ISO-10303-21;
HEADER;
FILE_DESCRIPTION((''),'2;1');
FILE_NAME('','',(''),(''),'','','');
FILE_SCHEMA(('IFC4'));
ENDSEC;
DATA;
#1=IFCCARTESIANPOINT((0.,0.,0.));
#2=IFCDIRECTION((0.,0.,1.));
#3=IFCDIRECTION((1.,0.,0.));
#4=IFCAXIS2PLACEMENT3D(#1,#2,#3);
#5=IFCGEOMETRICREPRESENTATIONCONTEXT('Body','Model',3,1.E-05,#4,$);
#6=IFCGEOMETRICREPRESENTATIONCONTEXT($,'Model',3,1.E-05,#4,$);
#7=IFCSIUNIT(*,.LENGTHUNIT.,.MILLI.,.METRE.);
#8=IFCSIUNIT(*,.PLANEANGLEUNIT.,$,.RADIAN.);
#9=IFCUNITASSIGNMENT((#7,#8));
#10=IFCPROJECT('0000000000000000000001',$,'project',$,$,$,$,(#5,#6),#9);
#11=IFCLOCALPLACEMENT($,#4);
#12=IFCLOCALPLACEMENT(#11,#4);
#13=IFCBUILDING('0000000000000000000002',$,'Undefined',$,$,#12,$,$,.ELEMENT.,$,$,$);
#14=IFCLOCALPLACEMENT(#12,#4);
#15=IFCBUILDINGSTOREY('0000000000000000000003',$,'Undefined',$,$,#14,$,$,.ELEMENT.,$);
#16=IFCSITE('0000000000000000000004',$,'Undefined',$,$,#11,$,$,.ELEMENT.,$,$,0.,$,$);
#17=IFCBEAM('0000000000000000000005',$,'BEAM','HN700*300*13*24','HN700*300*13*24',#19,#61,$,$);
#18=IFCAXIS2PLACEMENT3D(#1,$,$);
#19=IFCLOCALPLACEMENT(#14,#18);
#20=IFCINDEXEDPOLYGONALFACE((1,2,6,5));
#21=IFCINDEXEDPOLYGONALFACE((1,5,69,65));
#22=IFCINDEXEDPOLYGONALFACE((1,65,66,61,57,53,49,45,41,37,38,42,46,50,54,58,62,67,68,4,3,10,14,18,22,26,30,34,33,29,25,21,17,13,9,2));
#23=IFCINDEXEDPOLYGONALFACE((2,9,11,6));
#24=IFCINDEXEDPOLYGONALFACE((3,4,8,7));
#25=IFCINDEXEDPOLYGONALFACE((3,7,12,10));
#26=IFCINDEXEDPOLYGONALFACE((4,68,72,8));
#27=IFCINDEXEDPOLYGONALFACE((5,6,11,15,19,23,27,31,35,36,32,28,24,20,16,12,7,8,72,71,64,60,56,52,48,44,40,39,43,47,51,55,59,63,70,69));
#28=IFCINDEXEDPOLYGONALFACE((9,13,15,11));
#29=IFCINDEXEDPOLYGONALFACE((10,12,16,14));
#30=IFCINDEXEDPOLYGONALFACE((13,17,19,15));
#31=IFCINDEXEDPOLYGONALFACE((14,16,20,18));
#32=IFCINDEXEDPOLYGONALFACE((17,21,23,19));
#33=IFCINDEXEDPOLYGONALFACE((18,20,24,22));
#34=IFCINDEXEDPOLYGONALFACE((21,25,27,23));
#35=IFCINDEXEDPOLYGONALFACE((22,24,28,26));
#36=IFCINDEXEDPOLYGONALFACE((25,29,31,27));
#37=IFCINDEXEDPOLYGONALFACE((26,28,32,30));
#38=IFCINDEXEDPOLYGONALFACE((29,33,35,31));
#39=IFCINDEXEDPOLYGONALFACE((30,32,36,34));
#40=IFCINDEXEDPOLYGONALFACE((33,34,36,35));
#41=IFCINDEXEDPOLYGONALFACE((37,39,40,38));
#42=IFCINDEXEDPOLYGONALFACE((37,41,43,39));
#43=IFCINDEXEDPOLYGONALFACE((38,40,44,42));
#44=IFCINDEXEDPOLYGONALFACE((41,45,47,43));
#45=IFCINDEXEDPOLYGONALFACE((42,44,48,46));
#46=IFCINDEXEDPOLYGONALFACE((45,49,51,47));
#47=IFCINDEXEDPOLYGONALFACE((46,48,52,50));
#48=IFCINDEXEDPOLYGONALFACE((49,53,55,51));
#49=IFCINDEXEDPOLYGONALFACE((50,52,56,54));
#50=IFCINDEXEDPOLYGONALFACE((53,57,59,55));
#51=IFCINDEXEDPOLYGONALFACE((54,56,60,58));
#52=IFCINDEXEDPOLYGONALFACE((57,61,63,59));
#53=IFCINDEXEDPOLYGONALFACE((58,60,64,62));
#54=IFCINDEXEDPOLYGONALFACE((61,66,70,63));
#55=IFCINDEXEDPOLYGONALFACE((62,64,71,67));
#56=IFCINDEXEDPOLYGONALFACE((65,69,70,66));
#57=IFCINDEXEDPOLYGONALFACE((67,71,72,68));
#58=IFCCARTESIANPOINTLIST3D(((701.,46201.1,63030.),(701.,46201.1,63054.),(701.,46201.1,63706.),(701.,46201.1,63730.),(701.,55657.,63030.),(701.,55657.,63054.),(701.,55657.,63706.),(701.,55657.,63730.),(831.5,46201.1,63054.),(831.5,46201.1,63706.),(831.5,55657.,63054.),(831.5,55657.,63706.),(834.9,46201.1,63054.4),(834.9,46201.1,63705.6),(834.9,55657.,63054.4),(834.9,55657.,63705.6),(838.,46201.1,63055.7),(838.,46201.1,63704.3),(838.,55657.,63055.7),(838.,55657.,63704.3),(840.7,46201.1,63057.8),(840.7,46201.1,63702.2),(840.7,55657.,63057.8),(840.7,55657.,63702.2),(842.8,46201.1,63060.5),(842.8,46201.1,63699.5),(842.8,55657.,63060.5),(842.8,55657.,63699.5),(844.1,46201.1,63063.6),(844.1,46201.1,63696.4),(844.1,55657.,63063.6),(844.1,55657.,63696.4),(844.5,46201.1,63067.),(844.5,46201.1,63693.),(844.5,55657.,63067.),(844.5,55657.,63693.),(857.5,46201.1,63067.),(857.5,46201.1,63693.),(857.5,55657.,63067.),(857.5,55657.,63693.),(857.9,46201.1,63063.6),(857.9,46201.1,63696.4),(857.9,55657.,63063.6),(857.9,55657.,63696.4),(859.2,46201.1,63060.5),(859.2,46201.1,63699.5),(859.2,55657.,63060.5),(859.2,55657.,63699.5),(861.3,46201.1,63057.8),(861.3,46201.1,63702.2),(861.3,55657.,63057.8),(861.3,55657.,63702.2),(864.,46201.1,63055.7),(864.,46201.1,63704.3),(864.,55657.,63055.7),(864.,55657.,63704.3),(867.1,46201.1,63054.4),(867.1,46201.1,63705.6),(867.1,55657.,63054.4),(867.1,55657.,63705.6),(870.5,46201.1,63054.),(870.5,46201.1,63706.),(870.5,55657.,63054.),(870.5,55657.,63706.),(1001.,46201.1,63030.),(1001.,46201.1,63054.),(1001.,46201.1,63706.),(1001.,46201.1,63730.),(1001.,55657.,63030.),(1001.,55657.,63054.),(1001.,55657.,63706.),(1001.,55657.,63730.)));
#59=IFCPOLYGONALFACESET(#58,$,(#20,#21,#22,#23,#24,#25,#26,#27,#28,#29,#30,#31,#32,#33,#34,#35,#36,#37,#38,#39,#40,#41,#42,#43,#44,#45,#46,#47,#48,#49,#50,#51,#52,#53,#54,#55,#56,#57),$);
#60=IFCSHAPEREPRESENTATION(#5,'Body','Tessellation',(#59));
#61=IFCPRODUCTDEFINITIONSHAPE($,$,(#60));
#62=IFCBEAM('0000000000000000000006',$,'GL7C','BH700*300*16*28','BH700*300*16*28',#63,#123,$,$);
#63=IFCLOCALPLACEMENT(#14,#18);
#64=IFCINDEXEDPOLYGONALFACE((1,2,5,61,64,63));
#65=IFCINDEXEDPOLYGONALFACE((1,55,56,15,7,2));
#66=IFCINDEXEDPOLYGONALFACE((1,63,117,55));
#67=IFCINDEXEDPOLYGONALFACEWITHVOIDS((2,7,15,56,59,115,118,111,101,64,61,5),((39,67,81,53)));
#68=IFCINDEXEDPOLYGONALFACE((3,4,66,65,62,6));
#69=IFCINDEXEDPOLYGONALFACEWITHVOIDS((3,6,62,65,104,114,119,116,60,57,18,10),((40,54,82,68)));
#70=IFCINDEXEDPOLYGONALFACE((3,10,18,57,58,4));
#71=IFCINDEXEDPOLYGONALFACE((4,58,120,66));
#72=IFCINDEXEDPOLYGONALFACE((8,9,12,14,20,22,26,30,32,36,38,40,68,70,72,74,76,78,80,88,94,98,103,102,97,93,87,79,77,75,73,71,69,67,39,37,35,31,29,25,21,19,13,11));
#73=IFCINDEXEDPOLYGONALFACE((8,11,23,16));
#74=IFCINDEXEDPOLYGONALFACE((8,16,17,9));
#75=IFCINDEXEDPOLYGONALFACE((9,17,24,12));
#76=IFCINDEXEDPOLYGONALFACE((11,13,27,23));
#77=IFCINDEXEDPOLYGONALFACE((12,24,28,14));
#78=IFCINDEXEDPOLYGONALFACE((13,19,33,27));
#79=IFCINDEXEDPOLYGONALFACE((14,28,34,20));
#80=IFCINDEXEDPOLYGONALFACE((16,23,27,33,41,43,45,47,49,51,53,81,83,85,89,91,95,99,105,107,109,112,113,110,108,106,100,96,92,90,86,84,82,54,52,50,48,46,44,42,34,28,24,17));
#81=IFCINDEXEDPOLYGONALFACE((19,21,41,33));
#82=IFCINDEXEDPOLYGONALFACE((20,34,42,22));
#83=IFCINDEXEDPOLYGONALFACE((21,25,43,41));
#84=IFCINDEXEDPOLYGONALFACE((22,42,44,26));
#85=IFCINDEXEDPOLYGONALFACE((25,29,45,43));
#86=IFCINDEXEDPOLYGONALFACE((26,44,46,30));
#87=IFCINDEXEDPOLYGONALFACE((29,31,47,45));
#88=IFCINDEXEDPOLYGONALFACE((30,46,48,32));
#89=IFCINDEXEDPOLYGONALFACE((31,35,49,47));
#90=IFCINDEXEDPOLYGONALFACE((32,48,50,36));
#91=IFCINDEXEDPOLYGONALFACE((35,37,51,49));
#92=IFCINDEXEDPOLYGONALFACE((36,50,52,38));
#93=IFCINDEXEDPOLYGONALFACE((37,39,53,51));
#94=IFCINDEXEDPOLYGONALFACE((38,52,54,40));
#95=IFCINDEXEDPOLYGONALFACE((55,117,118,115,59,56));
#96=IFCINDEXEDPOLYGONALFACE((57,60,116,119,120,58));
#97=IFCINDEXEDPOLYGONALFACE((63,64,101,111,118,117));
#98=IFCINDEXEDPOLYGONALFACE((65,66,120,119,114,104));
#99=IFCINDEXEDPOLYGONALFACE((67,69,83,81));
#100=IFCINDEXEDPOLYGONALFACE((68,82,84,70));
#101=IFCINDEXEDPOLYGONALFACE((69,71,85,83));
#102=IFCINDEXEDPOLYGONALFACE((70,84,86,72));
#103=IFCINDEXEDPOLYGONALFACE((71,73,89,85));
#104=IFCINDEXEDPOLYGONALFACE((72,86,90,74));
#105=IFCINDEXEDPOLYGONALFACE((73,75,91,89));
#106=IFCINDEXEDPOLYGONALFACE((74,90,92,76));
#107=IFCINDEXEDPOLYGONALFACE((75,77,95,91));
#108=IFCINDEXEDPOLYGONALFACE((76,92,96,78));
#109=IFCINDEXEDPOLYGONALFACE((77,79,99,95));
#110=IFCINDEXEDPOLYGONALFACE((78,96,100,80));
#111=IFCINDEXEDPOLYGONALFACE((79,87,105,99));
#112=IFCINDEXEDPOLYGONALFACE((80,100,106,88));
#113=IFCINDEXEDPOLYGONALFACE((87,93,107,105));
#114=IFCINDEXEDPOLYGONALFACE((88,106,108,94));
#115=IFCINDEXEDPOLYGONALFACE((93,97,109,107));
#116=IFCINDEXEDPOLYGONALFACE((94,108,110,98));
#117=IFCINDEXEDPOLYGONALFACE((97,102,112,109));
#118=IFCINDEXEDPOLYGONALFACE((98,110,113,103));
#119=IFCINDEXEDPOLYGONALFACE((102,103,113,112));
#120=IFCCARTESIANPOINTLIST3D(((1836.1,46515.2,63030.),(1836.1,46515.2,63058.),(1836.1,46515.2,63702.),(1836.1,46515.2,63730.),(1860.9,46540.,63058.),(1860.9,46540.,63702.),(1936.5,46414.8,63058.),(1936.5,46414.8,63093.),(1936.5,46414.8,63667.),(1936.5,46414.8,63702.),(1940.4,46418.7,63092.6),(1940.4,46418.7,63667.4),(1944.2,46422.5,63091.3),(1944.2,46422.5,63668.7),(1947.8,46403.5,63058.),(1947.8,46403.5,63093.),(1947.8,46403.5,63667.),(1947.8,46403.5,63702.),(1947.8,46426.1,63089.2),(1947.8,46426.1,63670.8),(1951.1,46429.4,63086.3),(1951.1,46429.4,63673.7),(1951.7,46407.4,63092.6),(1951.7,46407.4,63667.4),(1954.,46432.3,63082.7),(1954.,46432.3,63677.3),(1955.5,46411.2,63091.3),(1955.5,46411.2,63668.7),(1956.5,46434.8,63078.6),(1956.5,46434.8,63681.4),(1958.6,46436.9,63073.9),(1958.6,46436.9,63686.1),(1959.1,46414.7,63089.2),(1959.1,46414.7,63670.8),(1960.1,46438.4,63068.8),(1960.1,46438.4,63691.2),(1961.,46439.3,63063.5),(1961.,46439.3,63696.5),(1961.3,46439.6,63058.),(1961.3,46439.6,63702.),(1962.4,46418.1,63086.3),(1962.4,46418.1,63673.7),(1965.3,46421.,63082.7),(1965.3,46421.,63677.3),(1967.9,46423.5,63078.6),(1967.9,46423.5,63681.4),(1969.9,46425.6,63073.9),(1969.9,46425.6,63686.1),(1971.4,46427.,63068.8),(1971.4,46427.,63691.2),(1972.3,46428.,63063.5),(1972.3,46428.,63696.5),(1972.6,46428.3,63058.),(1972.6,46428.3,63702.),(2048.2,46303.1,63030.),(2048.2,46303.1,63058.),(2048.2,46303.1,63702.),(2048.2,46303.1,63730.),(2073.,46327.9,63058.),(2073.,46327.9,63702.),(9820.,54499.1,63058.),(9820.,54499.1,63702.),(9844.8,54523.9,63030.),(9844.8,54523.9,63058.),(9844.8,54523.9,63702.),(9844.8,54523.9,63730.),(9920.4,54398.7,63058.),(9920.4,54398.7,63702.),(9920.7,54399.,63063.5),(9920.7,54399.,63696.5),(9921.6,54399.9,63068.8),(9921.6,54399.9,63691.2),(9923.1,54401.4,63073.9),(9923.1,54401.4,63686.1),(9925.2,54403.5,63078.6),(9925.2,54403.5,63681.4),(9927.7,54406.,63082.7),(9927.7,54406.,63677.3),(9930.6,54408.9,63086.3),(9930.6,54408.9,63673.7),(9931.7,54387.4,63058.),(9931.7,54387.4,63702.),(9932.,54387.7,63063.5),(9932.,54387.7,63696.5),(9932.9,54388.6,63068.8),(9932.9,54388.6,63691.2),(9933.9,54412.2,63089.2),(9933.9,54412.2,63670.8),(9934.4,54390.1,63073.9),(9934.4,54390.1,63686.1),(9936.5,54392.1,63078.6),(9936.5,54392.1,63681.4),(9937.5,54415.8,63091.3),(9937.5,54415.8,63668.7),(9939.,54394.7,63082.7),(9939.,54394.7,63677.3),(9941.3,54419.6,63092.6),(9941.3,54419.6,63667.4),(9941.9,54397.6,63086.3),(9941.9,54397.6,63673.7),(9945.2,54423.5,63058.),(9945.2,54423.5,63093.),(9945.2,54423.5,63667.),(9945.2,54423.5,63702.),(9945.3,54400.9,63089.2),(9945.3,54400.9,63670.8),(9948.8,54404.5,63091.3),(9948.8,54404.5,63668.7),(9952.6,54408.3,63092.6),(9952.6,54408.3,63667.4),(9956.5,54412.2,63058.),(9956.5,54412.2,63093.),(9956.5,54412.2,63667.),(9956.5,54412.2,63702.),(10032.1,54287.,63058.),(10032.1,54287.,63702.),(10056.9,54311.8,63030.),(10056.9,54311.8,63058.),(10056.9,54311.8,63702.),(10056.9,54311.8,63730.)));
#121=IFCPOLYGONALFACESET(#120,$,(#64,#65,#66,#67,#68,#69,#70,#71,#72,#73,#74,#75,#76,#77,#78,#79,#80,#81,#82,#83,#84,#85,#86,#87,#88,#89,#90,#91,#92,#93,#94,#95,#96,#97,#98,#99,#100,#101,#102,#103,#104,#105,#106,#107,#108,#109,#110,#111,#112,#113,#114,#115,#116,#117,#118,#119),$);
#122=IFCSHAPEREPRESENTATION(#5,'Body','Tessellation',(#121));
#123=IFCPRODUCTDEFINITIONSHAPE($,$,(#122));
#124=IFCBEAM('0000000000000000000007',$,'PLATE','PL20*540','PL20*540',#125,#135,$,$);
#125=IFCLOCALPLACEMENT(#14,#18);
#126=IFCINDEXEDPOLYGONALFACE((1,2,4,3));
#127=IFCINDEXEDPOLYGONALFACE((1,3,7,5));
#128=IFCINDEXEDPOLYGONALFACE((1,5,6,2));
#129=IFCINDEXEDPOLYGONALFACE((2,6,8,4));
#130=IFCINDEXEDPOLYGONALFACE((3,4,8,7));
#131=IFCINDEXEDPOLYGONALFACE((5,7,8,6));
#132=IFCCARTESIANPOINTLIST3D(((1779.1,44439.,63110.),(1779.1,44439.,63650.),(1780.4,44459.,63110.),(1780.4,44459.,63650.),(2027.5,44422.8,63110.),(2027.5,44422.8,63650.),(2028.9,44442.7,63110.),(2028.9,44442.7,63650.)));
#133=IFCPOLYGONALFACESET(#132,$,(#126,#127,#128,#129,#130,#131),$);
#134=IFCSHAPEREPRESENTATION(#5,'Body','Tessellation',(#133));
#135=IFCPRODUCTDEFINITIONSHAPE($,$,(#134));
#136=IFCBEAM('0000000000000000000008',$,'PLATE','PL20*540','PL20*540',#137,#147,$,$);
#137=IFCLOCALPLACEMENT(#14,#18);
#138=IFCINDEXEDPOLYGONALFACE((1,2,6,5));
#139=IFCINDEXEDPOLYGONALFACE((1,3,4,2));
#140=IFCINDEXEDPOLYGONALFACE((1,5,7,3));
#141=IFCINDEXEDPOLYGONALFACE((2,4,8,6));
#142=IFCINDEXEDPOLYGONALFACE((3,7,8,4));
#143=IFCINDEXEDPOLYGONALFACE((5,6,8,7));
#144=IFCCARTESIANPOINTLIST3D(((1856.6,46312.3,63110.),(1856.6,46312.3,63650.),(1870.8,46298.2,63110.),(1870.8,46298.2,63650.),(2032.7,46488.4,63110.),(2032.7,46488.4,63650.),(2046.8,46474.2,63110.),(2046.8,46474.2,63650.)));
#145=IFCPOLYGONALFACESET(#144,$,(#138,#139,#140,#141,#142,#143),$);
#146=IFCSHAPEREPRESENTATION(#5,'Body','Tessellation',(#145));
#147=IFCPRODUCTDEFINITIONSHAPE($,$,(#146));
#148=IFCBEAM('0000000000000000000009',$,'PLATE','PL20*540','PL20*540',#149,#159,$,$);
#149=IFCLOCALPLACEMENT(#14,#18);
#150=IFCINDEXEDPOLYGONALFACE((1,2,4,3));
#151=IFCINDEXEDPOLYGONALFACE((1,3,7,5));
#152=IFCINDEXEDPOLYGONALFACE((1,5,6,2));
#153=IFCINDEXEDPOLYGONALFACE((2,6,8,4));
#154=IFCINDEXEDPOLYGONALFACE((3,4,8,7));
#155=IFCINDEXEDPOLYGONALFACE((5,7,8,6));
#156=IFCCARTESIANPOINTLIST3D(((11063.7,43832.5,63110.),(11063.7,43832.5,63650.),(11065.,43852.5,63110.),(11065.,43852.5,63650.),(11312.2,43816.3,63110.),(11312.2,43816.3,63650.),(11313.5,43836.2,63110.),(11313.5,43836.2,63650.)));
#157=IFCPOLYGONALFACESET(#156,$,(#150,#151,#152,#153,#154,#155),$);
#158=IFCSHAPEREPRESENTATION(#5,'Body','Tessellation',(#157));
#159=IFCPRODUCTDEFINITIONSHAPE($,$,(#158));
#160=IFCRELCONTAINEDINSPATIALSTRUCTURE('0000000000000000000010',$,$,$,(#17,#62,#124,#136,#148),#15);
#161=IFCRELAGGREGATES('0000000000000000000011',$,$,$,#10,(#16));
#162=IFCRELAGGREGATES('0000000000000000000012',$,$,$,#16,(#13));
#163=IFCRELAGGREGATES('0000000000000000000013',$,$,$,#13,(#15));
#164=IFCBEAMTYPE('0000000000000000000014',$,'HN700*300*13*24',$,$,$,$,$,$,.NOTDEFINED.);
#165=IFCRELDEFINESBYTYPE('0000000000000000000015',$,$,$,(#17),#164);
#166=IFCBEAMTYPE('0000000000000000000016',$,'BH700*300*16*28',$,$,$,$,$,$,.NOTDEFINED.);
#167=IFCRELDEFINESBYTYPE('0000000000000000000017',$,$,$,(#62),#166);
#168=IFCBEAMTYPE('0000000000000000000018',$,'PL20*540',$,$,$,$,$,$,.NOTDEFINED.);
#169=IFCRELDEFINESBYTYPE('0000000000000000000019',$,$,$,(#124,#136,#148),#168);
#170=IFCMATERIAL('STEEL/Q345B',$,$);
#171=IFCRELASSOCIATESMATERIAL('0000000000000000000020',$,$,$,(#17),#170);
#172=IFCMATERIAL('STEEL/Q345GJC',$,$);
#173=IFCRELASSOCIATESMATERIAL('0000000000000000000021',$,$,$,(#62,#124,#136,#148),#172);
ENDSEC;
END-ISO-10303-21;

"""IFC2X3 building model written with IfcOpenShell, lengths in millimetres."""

from ifc_helpers import new_model, si_unit, frame, origin_with_axes, origin_2d_with_axis, place, context, project, spatial, polyline, rectangle, i_section, outline, extrude, material, type_object, element, save


model = new_model("IFC2X3")

# Units and contexts
model_context_1 = context("Model", 3, precision=1e-05, world=origin_with_axes(), identifier="Body")
model_context_2 = context("Model", 3, precision=1e-05, world=origin_with_axes())
ifc_project = project(units=[si_unit("LENGTHUNIT", "METRE", prefix="MILLI"), si_unit("PLANEANGLEUNIT", "RADIAN")], contexts=[model_context_1, model_context_2])

# Site, building, storey
site_placement = place(None, origin_with_axes())
site = spatial("IfcSite", under=ifc_project, at=site_placement, Name="Undefined", CompositionType="ELEMENT", RefElevation=0.0)
building_placement = place(site_placement, origin_with_axes())
building = spatial("IfcBuilding", under=site, at=building_placement, Name="Undefined", CompositionType="ELEMENT")
storey_placement = place(building_placement, origin_with_axes())
storey = spatial("IfcBuildingStorey", under=building, at=storey_placement, Name="Undefined", CompositionType="ELEMENT")

# Beam
ifc_material_1 = material(Name="STEEL/Q345B")
beam_type_1 = type_object("IfcBeamType", Name="HN700*300*13*24", PredefinedType="NOTDEFINED")
beam_1_placement = place(storey_placement, frame((851.0, 46201.1, 63380.0), z_axis=(0.0, 0.0, 1.0), x_axis=(0.0, 1.0, 0.0)))
element("IfcBeam", 1, at=beam_1_placement, inside=storey, type_object=beam_type_1, material=ifc_material_1, Name="BEAM", Description="HN700*300*13*24", ObjectType="HN700*300*13*24", context=model_context_1, shape_type="SweptSolid", body=[
    extrude(i_section(OverallWidth=300.0, OverallDepth=700.0, WebThickness=13.0, FlangeThickness=24.0, FilletRadius=13.0, at=origin_2d_with_axis()), frame((9455.9, 0.0, 0.0), z_axis=(-1.0, 0.0, 0.0), x_axis=(0.0, -1.0, 0.0)), (0.0, 0.0, 1.0), 9455.9),
])
ifc_material_2 = material(Name="STEEL/Q345GJC")
beam_type_2 = type_object("IfcBeamType", Name="BH700*300*16*28", PredefinedType="NOTDEFINED")

# Beam, openings
beam_2_placement = place(storey_placement, frame((992.3, 45459.3, 63380.0), z_axis=(0.0, 0.0, 1.0), x_axis=(0.707107, 0.707107, 0.0)))
beam_2 = element("IfcBeam", 2, at=beam_2_placement, inside=storey, type_object=beam_type_2, material=ifc_material_2, Name="GL7C", Description="BH700*300*16*28", ObjectType="BH700*300*16*28", context=model_context_1, shape_type="SweptSolid", body=[
    extrude(i_section(OverallWidth=300.0, OverallDepth=700.0, WebThickness=16.0, FlangeThickness=28.0, at=origin_2d_with_axis()), frame((12669.3, 0.0, 0.0), z_axis=(-1.0, 0.0, 0.0), x_axis=(0.0, -1.0, 0.0)), (0.0, 0.0, 1.0), 11325.9),
])
opening_1_placement = place(storey_placement, frame((992.3, 45459.3, 63380.0), z_axis=(0.0, 0.0, 1.0), x_axis=(0.707107, 0.707107, 0.0)))
element("IfcOpeningElement", 3, at=opening_1_placement, cuts=beam_2, ObjectType="Recess", context=model_context_1, shape_type="SweptSolid", body=[
    extrude(outline(polyline([(0.0, 0.0), (37.0, 0.0), (37.0, 35.0), (35.0, 35.0), (29.5, 34.6), (24.2, 33.3), (19.1, 31.2), (14.4, 28.3), (10.3, 24.7), (6.7, 20.6), (3.8, 15.9), (1.7, 10.8), (0.4, 5.5), (0.0, 0.0), (0.0, 0.0)])), frame((12634.3, -150.0, 322.0), z_axis=(0.0, 1.0, 0.0), x_axis=(1.0, 0.0, 0.0)), (0.0, 0.0, 1.0), 300.0),
])
opening_2_placement = place(storey_placement, frame((992.3, 45459.3, 63380.0), z_axis=(0.0, 0.0, 1.0), x_axis=(0.707107, 0.707107, 0.0)))
element("IfcOpeningElement", 4, at=opening_2_placement, cuts=beam_2, ObjectType="Recess", context=model_context_1, shape_type="SweptSolid", body=[
    extrude(outline(polyline([(0.0, 0.0), (37.0, 0.0), (36.6, 5.5), (35.3, 10.8), (33.2, 15.9), (30.3, 20.6), (26.7, 24.7), (22.6, 28.3), (17.9, 31.2), (12.8, 33.3), (7.5, 34.6), (2.0, 35.0), (0.0, 35.0), (0.0, 0.0)])), frame((12671.3, -150.0, -322.0), z_axis=(0.0, 1.0, 0.0), x_axis=(-1.0, 0.0, 0.0)), (0.0, 0.0, 1.0), 300.0),
])
opening_3_placement = place(storey_placement, frame((992.3, 45459.3, 63380.0), z_axis=(0.0, 0.0, 1.0), x_axis=(0.707107, 0.707107, 0.0)))
element("IfcOpeningElement", 5, at=opening_3_placement, cuts=beam_2, ObjectType="Recess", context=model_context_1, shape_type="SweptSolid", body=[
    extrude(outline(polyline([(0.0, 0.0), (37.0, 0.0), (37.0, 35.0), (35.0, 35.0), (29.5, 34.6), (24.2, 33.3), (19.1, 31.2), (14.4, 28.3), (10.3, 24.7), (6.7, 20.6), (3.8, 15.9), (1.7, 10.8), (0.4, 5.5), (0.0, 0.0), (0.0, 0.0)])), frame((1378.4, 150.0, 322.0), z_axis=(0.0, -1.0, 0.0), x_axis=(-1.0, 0.0, 0.0)), (0.0, 0.0, 1.0), 300.0),
])
opening_4_placement = place(storey_placement, frame((992.3, 45459.3, 63380.0), z_axis=(0.0, 0.0, 1.0), x_axis=(0.707107, 0.707107, 0.0)))
element("IfcOpeningElement", 6, at=opening_4_placement, cuts=beam_2, ObjectType="Recess", context=model_context_1, shape_type="SweptSolid", body=[
    extrude(outline(polyline([(0.0, 0.0), (37.0, 0.0), (36.6, 5.5), (35.3, 10.8), (33.2, 15.9), (30.3, 20.6), (26.7, 24.7), (22.6, 28.3), (17.9, 31.2), (12.8, 33.3), (7.5, 34.6), (2.0, 35.0), (0.0, 35.0), (0.0, 0.0)])), frame((1341.4, 150.0, -322.0), z_axis=(0.0, -1.0, 0.0), x_axis=(1.0, 0.0, 0.0)), (0.0, 0.0, 1.0), 300.0),
])
opening_5_placement = place(storey_placement, frame((992.3, 45459.3, 63380.0), z_axis=(0.0, 0.0, 1.0), x_axis=(0.707107, 0.707107, 0.0)))
element("IfcOpeningElement", 7, at=opening_5_placement, cuts=beam_2, ObjectType="Recess", context=model_context_1, shape_type="SweptSolid", body=[
    extrude(outline(polyline([(0.0, 0.0), (37.0, 0.0), (37.0, 35.0), (35.0, 35.0), (29.5, 34.6), (24.2, 33.3), (19.1, 31.2), (14.4, 28.3), (10.3, 24.7), (6.7, 20.6), (3.8, 15.9), (1.7, 10.8), (0.4, 5.5), (0.0, 0.0), (0.0, 0.0)])), frame((1378.4, 150.0, 322.0), z_axis=(0.0, -1.0, 0.0), x_axis=(-1.0, 0.0, 0.0)), (0.0, 0.0, 1.0), 300.0),
])
opening_6_placement = place(storey_placement, frame((992.3, 45459.3, 63380.0), z_axis=(0.0, 0.0, 1.0), x_axis=(0.707107, 0.707107, 0.0)))
element("IfcOpeningElement", 8, at=opening_6_placement, cuts=beam_2, ObjectType="Recess", context=model_context_1, shape_type="SweptSolid", body=[
    extrude(outline(polyline([(0.0, 0.0), (37.0, 0.0), (36.6, 5.5), (35.3, 10.8), (33.2, 15.9), (30.3, 20.6), (26.7, 24.7), (22.6, 28.3), (17.9, 31.2), (12.8, 33.3), (7.5, 34.6), (2.0, 35.0), (0.0, 35.0), (0.0, 0.0)])), frame((1341.4, 150.0, -322.0), z_axis=(0.0, -1.0, 0.0), x_axis=(1.0, 0.0, 0.0)), (0.0, 0.0, 1.0), 300.0),
])

# Beams
beam_type_3 = type_object("IfcBeamType", Name="PL20*540", PredefinedType="NOTDEFINED")
beam_3_placement = place(storey_placement, frame((1779.7, 44449.0, 63380.0), z_axis=(0.0, 0.0, 1.0), x_axis=(0.997873, -0.065183, 0.0)))
element("IfcBeam", 9, at=beam_3_placement, inside=storey, type_object=beam_type_3, material=ifc_material_2, Name="PLATE", Description="PL20*540", ObjectType="PL20*540", context=model_context_1, shape_type="SweptSolid", body=[
    extrude(rectangle(XDim=20.0, YDim=540.0, at=origin_2d_with_axis()), frame((249.0, 0.0, 0.0), z_axis=(-1.0, 0.0, 0.0), x_axis=(0.0, -1.0, 0.0)), (0.0, 0.0, 1.0), 249.0),
])
beam_4_placement = place(storey_placement, frame((1863.7, 46305.2, 63380.0), z_axis=(0.0, 0.0, 1.0), x_axis=(0.707107, 0.707107, 0.0)))
element("IfcBeam", 10, at=beam_4_placement, inside=storey, type_object=beam_type_3, material=ifc_material_2, Name="PLATE", Description="PL20*540", ObjectType="PL20*540", context=model_context_1, shape_type="SweptSolid", body=[
    extrude(rectangle(XDim=20.0, YDim=540.0, at=origin_2d_with_axis()), frame((249.0, 0.0, 0.0), z_axis=(-1.0, 0.0, 0.0), x_axis=(0.0, -1.0, 0.0)), (0.0, 0.0, 1.0), 249.0),
])
beam_5_placement = place(storey_placement, frame((11312.8, 43826.3, 63380.0), z_axis=(0.0, 0.0, 1.0), x_axis=(-0.997873, 0.065184, 0.0)))
element("IfcBeam", 11, at=beam_5_placement, inside=storey, type_object=beam_type_3, material=ifc_material_2, Name="PLATE", Description="PL20*540", ObjectType="PL20*540", context=model_context_1, shape_type="SweptSolid", body=[
    extrude(rectangle(XDim=20.0, YDim=540.0, at=origin_2d_with_axis()), frame((249.0, 0.0, 0.0), z_axis=(-1.0, 0.0, 0.0), x_axis=(0.0, -1.0, 0.0)), (0.0, 0.0, 1.0), 249.0),
])

save(model, "model.ifc")
